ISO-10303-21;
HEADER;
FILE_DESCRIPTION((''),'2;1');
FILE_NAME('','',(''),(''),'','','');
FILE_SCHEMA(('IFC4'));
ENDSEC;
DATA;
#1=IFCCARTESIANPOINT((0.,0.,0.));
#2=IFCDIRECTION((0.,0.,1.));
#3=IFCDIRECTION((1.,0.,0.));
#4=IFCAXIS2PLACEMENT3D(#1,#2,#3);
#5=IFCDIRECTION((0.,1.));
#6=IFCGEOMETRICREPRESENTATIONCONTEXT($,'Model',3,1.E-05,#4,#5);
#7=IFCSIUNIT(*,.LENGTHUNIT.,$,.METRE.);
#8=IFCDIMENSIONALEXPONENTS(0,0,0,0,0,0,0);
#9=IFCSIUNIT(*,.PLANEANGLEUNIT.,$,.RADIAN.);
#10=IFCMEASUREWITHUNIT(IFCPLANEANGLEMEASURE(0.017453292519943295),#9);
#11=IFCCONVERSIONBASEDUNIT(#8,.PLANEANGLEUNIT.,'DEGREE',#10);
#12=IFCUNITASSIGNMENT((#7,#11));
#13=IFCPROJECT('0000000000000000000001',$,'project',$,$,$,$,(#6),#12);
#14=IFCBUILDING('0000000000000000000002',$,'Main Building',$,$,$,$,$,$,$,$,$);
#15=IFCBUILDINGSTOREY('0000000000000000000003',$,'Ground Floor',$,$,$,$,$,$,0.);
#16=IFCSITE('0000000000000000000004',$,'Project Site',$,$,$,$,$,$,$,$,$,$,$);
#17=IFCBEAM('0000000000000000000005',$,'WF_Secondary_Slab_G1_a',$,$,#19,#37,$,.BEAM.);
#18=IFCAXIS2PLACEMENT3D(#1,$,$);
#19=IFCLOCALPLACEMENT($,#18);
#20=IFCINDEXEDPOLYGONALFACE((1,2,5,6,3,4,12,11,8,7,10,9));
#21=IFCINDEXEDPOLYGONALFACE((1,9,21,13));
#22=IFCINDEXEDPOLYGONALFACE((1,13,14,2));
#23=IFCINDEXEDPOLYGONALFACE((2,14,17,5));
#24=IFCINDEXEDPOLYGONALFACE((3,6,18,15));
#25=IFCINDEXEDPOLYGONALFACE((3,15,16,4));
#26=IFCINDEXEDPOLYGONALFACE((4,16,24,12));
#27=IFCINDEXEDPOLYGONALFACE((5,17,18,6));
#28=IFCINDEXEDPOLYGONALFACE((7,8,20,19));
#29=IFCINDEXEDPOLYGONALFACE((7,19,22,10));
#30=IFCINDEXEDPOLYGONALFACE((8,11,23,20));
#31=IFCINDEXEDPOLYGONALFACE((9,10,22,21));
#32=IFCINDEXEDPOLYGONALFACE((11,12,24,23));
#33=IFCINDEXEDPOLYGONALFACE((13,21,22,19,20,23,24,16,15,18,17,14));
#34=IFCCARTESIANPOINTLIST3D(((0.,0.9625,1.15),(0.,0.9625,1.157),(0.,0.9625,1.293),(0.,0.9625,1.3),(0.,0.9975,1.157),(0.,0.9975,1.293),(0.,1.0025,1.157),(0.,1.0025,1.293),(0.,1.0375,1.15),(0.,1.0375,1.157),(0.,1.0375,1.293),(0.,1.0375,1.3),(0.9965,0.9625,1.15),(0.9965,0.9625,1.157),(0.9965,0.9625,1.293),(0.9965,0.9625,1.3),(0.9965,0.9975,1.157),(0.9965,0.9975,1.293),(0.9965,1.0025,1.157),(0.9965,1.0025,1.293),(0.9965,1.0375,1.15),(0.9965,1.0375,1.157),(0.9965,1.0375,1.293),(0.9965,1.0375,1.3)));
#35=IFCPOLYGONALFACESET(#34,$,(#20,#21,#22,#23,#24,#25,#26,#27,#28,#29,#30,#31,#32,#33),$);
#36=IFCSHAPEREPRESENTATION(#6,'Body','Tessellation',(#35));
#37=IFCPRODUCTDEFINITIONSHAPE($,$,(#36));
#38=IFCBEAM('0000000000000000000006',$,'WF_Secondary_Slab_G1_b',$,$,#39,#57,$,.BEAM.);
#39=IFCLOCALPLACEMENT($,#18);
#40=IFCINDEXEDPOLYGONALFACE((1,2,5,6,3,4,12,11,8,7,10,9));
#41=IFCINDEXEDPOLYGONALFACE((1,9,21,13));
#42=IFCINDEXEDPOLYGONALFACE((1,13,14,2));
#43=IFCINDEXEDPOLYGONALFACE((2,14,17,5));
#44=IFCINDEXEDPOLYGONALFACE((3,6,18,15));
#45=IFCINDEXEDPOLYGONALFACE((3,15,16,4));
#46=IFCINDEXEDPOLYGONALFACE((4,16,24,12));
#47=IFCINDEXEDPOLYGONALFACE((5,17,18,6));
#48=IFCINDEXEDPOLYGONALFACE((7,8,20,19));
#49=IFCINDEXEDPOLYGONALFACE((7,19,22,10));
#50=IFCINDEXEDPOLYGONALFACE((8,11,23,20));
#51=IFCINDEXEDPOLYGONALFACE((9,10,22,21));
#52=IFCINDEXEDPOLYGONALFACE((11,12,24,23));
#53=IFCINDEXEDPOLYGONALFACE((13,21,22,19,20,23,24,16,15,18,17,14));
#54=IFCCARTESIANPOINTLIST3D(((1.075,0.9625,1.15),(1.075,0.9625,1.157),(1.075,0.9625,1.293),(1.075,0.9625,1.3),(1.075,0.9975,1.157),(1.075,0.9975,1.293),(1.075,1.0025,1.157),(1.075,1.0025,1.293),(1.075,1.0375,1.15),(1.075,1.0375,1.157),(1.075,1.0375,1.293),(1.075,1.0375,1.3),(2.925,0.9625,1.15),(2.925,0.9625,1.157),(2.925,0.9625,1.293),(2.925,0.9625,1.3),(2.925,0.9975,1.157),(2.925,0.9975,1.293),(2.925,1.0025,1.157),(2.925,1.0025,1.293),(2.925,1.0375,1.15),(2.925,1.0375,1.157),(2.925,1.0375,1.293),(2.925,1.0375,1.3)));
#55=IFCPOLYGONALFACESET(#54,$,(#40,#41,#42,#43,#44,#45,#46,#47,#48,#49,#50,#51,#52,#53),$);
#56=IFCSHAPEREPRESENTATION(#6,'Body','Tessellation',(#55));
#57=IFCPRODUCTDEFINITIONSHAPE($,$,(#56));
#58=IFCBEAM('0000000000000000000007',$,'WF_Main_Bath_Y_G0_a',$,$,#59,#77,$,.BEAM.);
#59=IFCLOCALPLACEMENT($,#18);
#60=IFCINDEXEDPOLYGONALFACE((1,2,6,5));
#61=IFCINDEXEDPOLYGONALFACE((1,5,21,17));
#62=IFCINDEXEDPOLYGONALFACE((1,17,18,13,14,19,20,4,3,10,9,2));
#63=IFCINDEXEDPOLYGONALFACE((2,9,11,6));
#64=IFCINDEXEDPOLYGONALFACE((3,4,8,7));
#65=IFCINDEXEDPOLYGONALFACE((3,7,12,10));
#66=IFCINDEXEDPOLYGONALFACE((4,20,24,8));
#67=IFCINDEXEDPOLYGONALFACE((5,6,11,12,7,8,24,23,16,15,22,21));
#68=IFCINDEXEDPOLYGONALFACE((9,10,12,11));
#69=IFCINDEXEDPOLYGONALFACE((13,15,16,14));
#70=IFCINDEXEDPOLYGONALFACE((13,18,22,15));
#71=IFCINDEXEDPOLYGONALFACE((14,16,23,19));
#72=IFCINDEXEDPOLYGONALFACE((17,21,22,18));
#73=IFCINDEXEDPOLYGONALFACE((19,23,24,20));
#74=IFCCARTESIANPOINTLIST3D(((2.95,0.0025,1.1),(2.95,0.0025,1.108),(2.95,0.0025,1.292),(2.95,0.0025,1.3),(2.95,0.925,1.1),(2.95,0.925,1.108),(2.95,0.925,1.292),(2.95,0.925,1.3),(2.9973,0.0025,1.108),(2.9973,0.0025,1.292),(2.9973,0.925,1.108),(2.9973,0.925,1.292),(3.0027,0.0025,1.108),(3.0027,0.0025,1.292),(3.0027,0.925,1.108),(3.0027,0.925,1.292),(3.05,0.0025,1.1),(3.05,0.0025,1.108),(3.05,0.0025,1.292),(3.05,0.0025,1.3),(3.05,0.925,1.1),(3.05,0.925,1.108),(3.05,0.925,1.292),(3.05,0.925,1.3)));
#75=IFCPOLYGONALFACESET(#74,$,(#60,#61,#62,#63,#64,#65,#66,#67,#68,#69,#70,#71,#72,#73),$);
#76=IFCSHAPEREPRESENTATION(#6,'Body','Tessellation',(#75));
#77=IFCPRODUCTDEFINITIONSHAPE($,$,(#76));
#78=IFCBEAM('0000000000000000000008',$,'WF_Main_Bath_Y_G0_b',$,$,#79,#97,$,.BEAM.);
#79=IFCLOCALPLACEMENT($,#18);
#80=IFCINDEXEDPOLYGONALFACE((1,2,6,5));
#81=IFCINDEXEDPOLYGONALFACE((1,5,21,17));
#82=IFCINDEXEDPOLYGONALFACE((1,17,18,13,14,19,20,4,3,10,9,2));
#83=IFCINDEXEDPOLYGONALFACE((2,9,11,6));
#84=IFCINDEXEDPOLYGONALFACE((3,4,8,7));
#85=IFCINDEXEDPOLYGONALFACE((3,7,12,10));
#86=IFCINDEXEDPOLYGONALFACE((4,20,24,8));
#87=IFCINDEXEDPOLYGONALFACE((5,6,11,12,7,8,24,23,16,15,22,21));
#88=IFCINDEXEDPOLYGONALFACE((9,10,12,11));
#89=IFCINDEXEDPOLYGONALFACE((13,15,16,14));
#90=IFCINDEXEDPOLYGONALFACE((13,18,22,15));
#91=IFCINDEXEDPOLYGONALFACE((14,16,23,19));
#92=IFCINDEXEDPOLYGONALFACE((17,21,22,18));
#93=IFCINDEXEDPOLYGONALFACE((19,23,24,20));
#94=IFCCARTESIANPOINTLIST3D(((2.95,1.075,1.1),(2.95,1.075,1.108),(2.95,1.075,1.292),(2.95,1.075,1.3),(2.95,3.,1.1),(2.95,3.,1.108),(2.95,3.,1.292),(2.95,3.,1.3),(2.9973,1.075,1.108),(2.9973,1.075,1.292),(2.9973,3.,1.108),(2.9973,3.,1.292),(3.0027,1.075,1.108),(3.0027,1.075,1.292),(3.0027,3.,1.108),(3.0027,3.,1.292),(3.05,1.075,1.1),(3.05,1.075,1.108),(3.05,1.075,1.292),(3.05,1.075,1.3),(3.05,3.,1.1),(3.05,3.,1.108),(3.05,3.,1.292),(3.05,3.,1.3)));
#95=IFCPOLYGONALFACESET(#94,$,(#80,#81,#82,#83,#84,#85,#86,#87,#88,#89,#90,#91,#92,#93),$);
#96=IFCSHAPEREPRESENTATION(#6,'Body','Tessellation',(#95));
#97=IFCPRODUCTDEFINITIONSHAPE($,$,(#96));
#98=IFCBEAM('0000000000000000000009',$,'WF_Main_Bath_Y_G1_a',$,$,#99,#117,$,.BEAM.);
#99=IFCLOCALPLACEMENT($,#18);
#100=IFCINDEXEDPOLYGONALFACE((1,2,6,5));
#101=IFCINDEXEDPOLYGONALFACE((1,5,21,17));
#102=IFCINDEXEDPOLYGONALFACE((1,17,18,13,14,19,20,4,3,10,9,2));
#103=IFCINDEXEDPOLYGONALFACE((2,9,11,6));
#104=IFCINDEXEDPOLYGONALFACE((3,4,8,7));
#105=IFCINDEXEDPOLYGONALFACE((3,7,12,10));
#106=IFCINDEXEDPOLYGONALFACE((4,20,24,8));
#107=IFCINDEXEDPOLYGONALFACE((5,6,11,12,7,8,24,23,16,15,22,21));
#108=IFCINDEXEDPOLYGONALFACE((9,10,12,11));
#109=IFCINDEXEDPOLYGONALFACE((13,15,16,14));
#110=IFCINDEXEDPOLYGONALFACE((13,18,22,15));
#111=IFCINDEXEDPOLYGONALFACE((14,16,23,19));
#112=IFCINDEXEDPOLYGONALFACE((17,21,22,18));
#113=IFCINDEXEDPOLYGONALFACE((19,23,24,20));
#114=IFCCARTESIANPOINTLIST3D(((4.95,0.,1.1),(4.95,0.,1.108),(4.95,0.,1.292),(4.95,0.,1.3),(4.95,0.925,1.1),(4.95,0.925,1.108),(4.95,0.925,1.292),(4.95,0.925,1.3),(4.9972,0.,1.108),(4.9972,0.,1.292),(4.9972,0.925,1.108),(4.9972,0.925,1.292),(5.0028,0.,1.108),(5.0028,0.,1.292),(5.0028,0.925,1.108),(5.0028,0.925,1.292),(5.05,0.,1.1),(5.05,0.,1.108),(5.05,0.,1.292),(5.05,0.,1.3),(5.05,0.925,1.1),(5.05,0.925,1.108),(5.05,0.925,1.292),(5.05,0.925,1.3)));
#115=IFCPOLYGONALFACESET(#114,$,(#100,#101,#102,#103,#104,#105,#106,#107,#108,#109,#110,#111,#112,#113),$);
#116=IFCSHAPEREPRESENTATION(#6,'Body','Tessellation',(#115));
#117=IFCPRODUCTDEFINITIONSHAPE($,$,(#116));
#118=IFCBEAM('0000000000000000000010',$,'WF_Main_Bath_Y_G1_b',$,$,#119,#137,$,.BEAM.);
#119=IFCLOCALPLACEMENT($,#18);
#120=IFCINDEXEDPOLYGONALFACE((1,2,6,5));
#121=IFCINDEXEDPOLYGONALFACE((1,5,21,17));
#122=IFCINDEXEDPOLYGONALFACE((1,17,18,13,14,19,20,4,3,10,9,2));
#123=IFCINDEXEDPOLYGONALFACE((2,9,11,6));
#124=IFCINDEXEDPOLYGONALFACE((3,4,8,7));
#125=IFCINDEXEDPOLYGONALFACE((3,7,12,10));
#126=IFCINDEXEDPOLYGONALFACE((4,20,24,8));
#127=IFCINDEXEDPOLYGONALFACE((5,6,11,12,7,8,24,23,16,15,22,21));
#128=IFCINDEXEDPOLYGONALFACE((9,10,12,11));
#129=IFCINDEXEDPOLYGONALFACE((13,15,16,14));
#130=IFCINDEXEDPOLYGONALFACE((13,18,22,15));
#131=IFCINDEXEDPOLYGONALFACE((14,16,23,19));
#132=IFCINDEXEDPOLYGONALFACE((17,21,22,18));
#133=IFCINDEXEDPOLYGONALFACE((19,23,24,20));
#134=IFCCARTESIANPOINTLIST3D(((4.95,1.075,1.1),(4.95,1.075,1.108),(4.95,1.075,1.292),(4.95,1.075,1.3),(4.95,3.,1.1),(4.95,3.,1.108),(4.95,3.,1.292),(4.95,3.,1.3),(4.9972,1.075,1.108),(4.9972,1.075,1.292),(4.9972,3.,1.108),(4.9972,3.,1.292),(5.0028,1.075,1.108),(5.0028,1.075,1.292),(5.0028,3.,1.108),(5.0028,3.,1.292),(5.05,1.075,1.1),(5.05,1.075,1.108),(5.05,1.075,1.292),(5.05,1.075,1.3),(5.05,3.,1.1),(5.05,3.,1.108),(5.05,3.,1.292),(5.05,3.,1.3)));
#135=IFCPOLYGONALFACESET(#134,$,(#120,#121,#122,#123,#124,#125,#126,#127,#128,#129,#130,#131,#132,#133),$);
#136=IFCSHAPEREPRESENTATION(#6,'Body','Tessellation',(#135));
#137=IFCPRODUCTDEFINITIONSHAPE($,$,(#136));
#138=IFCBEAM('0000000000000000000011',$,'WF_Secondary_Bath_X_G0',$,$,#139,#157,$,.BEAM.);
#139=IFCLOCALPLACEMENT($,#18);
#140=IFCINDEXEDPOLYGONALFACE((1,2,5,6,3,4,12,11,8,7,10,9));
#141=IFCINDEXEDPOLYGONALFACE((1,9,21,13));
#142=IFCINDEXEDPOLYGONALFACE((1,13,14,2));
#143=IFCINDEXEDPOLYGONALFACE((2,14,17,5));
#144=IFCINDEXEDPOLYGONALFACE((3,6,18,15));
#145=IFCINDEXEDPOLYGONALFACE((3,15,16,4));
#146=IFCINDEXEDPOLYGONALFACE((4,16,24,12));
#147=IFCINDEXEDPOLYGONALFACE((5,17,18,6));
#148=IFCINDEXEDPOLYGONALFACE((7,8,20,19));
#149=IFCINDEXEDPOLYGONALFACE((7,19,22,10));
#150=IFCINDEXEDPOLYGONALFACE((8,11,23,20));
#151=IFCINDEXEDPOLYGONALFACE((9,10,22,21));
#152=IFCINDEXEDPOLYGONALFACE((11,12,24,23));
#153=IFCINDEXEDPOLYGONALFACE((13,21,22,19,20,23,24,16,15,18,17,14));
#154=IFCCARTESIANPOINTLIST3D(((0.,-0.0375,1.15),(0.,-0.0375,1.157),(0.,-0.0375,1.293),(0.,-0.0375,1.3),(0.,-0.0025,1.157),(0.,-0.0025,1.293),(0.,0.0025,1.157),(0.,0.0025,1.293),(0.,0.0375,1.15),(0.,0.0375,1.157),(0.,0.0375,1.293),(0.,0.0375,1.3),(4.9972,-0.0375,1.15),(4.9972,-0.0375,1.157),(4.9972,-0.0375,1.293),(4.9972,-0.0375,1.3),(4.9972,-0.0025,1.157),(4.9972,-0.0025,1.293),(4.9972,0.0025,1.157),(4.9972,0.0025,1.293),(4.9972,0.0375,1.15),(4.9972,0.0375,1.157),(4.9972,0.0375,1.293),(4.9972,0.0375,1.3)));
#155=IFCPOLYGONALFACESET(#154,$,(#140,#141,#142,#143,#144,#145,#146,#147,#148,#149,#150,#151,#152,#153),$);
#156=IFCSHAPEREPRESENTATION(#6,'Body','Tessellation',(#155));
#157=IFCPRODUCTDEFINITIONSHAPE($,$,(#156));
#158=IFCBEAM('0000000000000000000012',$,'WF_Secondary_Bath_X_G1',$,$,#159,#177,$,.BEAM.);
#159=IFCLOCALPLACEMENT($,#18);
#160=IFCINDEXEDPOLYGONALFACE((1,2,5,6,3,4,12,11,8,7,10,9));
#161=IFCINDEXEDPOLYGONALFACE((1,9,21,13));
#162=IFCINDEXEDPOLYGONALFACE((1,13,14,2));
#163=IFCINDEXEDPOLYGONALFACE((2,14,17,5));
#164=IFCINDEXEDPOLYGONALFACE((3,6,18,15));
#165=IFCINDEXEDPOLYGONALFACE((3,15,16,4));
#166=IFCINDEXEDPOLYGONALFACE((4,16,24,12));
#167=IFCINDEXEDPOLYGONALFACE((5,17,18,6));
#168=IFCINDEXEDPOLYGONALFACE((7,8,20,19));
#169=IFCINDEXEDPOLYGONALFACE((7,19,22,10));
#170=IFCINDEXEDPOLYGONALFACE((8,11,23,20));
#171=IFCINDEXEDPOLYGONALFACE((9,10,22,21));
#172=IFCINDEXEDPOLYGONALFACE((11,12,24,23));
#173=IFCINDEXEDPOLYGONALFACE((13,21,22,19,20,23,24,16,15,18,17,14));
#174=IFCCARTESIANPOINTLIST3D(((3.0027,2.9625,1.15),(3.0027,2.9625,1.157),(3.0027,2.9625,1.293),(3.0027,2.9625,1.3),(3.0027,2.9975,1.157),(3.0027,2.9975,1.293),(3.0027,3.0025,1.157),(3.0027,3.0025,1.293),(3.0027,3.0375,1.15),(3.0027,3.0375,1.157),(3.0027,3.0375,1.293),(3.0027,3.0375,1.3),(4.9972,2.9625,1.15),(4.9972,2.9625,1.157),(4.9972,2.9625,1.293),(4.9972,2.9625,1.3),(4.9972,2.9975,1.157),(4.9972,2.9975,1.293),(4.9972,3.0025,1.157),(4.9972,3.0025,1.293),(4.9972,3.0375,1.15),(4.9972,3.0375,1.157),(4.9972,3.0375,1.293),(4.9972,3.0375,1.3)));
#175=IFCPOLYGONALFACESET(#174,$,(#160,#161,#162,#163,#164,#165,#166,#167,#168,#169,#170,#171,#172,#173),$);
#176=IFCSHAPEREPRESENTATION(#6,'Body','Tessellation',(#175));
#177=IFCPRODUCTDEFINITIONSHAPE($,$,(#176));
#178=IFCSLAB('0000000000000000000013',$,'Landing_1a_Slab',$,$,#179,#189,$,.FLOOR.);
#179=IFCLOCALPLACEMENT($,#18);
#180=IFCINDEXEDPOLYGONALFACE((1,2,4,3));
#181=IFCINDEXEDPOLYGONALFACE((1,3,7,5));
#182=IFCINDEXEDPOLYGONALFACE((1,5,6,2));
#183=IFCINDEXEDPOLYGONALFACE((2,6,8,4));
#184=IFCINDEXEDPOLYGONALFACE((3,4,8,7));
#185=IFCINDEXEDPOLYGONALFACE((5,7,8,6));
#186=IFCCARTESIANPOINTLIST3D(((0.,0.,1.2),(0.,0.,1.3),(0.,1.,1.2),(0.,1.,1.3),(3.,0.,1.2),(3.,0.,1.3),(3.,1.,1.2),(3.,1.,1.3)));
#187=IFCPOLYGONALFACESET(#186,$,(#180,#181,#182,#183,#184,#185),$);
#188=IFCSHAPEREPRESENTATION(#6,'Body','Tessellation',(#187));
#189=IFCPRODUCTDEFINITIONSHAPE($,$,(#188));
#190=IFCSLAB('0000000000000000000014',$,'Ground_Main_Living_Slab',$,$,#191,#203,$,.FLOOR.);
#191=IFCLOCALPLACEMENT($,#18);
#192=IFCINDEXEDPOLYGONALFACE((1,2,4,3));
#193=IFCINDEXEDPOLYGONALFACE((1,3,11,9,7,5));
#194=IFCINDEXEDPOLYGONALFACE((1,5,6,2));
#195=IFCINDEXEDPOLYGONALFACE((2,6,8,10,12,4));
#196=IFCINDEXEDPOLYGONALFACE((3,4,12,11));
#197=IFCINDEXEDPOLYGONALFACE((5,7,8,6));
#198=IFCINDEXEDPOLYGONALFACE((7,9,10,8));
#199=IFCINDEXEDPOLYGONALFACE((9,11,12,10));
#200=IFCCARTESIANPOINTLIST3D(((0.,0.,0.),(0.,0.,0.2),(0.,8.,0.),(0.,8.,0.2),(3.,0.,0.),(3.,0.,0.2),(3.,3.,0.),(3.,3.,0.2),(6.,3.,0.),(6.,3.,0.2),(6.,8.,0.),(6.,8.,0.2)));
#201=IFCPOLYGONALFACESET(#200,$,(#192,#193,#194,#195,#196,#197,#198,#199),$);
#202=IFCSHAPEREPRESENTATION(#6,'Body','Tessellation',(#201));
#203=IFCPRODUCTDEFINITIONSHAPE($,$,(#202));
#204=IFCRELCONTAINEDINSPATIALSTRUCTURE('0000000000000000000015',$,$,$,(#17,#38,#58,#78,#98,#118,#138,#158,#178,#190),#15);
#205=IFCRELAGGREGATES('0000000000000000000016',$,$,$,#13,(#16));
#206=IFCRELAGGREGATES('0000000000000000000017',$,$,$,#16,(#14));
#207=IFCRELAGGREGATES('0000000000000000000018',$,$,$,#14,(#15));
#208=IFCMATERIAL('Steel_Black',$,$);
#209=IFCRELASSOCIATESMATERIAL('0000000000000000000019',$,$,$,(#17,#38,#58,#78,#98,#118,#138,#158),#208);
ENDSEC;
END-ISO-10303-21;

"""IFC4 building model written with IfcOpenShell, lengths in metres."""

from ifc_helpers import new_model, entity, si_unit, converted_unit, direction, frame, frame_2d, origin, origin_with_axes, place, context, project, spatial, polyline, i_section, outline, extrude, material, element, save


model = new_model("IFC4")

# Units and contexts
model_context = context("Model", 3, precision=1e-05, world=origin_with_axes(), true_north=direction((0.0, 1.0)))
ifc_project = project(units=[si_unit("LENGTHUNIT", "METRE"), converted_unit("PLANEANGLEUNIT", "DEGREE", entity("IfcPlaneAngleMeasure", 0.017453292519943295), si_unit("PLANEANGLEUNIT", "RADIAN"), dimensions=[0, 0, 0, 0, 0, 0, 0])], contexts=[model_context])

# Site, building, storey
site = spatial("IfcSite", under=ifc_project, Name="Project Site")
building = spatial("IfcBuilding", under=site, Name="Main Building")
storey = spatial("IfcBuildingStorey", under=building, Name="Ground Floor", Elevation=0.0)

# Shared definitions
ifc_material = material(Name="Steel_Black")

# Beams
beam_1_placement = place(None, frame((0.0, 1.0, 1.15), z_axis=(0.0, 0.0, 1.0), x_axis=(1.0, 0.0, 0.0)))
element("IfcBeam", 1, at=beam_1_placement, inside=storey, material=ifc_material, Name="WF_Secondary_Slab_G1_a", PredefinedType="BEAM", context=model_context, shape_type="SweptSolid", body=[
    extrude(i_section(OverallWidth=0.075, OverallDepth=0.15, WebThickness=0.005, FlangeThickness=0.007, at=frame_2d((0.0, 0.075))), frame((0.0, 0.0, 0.0), z_axis=(1.0, 0.0, 0.0), x_axis=(0.0, 1.0, 0.0)), (0.0, 0.0, 1.0), 0.9965),
])
beam_2_placement = place(None, frame((1.075, 1.0, 1.15), z_axis=(0.0, 0.0, 1.0), x_axis=(1.0, 0.0, 0.0)))
element("IfcBeam", 2, at=beam_2_placement, inside=storey, material=ifc_material, Name="WF_Secondary_Slab_G1_b", PredefinedType="BEAM", context=model_context, shape_type="SweptSolid", body=[
    extrude(i_section(OverallWidth=0.075, OverallDepth=0.15, WebThickness=0.005, FlangeThickness=0.007, at=frame_2d((0.0, 0.075))), frame((0.0, 0.0, 0.0), z_axis=(1.0, 0.0, 0.0), x_axis=(0.0, 1.0, 0.0)), (0.0, 0.0, 1.0), 1.85),
])
beam_3_placement = place(None, frame((3.0, 0.0025, 1.1), z_axis=(0.0, 0.0, 1.0), x_axis=(0.0, 1.0, 0.0)))
element("IfcBeam", 3, at=beam_3_placement, inside=storey, material=ifc_material, Name="WF_Main_Bath_Y_G0_a", PredefinedType="BEAM", context=model_context, shape_type="SweptSolid", body=[
    extrude(i_section(OverallWidth=0.1, OverallDepth=0.2, WebThickness=0.0055, FlangeThickness=0.008, at=frame_2d((0.0, 0.1))), frame((0.0, 0.0, 0.0), z_axis=(1.0, 0.0, 0.0), x_axis=(0.0, 1.0, 0.0)), (0.0, 0.0, 1.0), 0.9225),
])
beam_4_placement = place(None, frame((3.0, 1.075, 1.1), z_axis=(0.0, 0.0, 1.0), x_axis=(0.0, 1.0, 0.0)))
element("IfcBeam", 4, at=beam_4_placement, inside=storey, material=ifc_material, Name="WF_Main_Bath_Y_G0_b", PredefinedType="BEAM", context=model_context, shape_type="SweptSolid", body=[
    extrude(i_section(OverallWidth=0.1, OverallDepth=0.2, WebThickness=0.0055, FlangeThickness=0.008, at=frame_2d((0.0, 0.1))), frame((0.0, 0.0, 0.0), z_axis=(1.0, 0.0, 0.0), x_axis=(0.0, 1.0, 0.0)), (0.0, 0.0, 1.0), 1.925),
])
beam_5_placement = place(None, frame((5.0, 0.0, 1.1), z_axis=(0.0, 0.0, 1.0), x_axis=(0.0, 1.0, 0.0)))
element("IfcBeam", 5, at=beam_5_placement, inside=storey, material=ifc_material, Name="WF_Main_Bath_Y_G1_a", PredefinedType="BEAM", context=model_context, shape_type="SweptSolid", body=[
    extrude(i_section(OverallWidth=0.1, OverallDepth=0.2, WebThickness=0.0055, FlangeThickness=0.008, at=frame_2d((0.0, 0.1))), frame((0.0, 0.0, 0.0), z_axis=(1.0, 0.0, 0.0), x_axis=(0.0, 1.0, 0.0)), (0.0, 0.0, 1.0), 0.925),
])
beam_6_placement = place(None, frame((5.0, 1.075, 1.1), z_axis=(0.0, 0.0, 1.0), x_axis=(0.0, 1.0, 0.0)))
element("IfcBeam", 6, at=beam_6_placement, inside=storey, material=ifc_material, Name="WF_Main_Bath_Y_G1_b", PredefinedType="BEAM", context=model_context, shape_type="SweptSolid", body=[
    extrude(i_section(OverallWidth=0.1, OverallDepth=0.2, WebThickness=0.0055, FlangeThickness=0.008, at=frame_2d((0.0, 0.1))), frame((0.0, 0.0, 0.0), z_axis=(1.0, 0.0, 0.0), x_axis=(0.0, 1.0, 0.0)), (0.0, 0.0, 1.0), 1.925),
])
beam_7_placement = place(None, frame((0.0, 0.0, 1.15), z_axis=(0.0, 0.0, 1.0), x_axis=(1.0, 0.0, 0.0)))
element("IfcBeam", 7, at=beam_7_placement, inside=storey, material=ifc_material, Name="WF_Secondary_Bath_X_G0", PredefinedType="BEAM", context=model_context, shape_type="SweptSolid", body=[
    extrude(i_section(OverallWidth=0.075, OverallDepth=0.15, WebThickness=0.005, FlangeThickness=0.007, at=frame_2d((0.0, 0.075))), frame((0.0, 0.0, 0.0), z_axis=(1.0, 0.0, 0.0), x_axis=(0.0, 1.0, 0.0)), (0.0, 0.0, 1.0), 4.9973),
])
beam_8_placement = place(None, frame((3.0027, 3.0, 1.15), z_axis=(0.0, 0.0, 1.0), x_axis=(1.0, 0.0, 0.0)))
element("IfcBeam", 8, at=beam_8_placement, inside=storey, material=ifc_material, Name="WF_Secondary_Bath_X_G1", PredefinedType="BEAM", context=model_context, shape_type="SweptSolid", body=[
    extrude(i_section(OverallWidth=0.075, OverallDepth=0.15, WebThickness=0.005, FlangeThickness=0.007, at=frame_2d((0.0, 0.075))), frame((0.0, 0.0, 0.0), z_axis=(1.0, 0.0, 0.0), x_axis=(0.0, 1.0, 0.0)), (0.0, 0.0, 1.0), 1.9945),
])

# Slabs
slab_1_placement = place(None, frame((0.0, 0.0, 1.2), z_axis=(0.0, 0.0, 1.0), x_axis=(1.0, 0.0, 0.0)))
element("IfcSlab", 9, at=slab_1_placement, inside=storey, Name="Landing_1a_Slab", PredefinedType="FLOOR", context=model_context, shape_type="SweptSolid", body=[
    extrude(outline(polyline([(0.0, 0.0), (3.0, 0.0), (3.0, 1.0), (0.0, 1.0), (0.0, 0.0)])), origin(), (0.0, 0.0, 1.0), 0.1),
])
slab_2_placement = place(None, origin_with_axes())
element("IfcSlab", 10, at=slab_2_placement, inside=storey, Name="Ground_Main_Living_Slab", PredefinedType="FLOOR", context=model_context, shape_type="SweptSolid", body=[
    extrude(outline(polyline([(0.0, 0.0), (3.0, 0.0), (3.0, 3.0), (6.0, 3.0), (6.0, 8.0), (0.0, 8.0), (0.0, 0.0)])), origin(), (0.0, 0.0, 1.0), 0.2),
])

save(model, "model.ifc")
